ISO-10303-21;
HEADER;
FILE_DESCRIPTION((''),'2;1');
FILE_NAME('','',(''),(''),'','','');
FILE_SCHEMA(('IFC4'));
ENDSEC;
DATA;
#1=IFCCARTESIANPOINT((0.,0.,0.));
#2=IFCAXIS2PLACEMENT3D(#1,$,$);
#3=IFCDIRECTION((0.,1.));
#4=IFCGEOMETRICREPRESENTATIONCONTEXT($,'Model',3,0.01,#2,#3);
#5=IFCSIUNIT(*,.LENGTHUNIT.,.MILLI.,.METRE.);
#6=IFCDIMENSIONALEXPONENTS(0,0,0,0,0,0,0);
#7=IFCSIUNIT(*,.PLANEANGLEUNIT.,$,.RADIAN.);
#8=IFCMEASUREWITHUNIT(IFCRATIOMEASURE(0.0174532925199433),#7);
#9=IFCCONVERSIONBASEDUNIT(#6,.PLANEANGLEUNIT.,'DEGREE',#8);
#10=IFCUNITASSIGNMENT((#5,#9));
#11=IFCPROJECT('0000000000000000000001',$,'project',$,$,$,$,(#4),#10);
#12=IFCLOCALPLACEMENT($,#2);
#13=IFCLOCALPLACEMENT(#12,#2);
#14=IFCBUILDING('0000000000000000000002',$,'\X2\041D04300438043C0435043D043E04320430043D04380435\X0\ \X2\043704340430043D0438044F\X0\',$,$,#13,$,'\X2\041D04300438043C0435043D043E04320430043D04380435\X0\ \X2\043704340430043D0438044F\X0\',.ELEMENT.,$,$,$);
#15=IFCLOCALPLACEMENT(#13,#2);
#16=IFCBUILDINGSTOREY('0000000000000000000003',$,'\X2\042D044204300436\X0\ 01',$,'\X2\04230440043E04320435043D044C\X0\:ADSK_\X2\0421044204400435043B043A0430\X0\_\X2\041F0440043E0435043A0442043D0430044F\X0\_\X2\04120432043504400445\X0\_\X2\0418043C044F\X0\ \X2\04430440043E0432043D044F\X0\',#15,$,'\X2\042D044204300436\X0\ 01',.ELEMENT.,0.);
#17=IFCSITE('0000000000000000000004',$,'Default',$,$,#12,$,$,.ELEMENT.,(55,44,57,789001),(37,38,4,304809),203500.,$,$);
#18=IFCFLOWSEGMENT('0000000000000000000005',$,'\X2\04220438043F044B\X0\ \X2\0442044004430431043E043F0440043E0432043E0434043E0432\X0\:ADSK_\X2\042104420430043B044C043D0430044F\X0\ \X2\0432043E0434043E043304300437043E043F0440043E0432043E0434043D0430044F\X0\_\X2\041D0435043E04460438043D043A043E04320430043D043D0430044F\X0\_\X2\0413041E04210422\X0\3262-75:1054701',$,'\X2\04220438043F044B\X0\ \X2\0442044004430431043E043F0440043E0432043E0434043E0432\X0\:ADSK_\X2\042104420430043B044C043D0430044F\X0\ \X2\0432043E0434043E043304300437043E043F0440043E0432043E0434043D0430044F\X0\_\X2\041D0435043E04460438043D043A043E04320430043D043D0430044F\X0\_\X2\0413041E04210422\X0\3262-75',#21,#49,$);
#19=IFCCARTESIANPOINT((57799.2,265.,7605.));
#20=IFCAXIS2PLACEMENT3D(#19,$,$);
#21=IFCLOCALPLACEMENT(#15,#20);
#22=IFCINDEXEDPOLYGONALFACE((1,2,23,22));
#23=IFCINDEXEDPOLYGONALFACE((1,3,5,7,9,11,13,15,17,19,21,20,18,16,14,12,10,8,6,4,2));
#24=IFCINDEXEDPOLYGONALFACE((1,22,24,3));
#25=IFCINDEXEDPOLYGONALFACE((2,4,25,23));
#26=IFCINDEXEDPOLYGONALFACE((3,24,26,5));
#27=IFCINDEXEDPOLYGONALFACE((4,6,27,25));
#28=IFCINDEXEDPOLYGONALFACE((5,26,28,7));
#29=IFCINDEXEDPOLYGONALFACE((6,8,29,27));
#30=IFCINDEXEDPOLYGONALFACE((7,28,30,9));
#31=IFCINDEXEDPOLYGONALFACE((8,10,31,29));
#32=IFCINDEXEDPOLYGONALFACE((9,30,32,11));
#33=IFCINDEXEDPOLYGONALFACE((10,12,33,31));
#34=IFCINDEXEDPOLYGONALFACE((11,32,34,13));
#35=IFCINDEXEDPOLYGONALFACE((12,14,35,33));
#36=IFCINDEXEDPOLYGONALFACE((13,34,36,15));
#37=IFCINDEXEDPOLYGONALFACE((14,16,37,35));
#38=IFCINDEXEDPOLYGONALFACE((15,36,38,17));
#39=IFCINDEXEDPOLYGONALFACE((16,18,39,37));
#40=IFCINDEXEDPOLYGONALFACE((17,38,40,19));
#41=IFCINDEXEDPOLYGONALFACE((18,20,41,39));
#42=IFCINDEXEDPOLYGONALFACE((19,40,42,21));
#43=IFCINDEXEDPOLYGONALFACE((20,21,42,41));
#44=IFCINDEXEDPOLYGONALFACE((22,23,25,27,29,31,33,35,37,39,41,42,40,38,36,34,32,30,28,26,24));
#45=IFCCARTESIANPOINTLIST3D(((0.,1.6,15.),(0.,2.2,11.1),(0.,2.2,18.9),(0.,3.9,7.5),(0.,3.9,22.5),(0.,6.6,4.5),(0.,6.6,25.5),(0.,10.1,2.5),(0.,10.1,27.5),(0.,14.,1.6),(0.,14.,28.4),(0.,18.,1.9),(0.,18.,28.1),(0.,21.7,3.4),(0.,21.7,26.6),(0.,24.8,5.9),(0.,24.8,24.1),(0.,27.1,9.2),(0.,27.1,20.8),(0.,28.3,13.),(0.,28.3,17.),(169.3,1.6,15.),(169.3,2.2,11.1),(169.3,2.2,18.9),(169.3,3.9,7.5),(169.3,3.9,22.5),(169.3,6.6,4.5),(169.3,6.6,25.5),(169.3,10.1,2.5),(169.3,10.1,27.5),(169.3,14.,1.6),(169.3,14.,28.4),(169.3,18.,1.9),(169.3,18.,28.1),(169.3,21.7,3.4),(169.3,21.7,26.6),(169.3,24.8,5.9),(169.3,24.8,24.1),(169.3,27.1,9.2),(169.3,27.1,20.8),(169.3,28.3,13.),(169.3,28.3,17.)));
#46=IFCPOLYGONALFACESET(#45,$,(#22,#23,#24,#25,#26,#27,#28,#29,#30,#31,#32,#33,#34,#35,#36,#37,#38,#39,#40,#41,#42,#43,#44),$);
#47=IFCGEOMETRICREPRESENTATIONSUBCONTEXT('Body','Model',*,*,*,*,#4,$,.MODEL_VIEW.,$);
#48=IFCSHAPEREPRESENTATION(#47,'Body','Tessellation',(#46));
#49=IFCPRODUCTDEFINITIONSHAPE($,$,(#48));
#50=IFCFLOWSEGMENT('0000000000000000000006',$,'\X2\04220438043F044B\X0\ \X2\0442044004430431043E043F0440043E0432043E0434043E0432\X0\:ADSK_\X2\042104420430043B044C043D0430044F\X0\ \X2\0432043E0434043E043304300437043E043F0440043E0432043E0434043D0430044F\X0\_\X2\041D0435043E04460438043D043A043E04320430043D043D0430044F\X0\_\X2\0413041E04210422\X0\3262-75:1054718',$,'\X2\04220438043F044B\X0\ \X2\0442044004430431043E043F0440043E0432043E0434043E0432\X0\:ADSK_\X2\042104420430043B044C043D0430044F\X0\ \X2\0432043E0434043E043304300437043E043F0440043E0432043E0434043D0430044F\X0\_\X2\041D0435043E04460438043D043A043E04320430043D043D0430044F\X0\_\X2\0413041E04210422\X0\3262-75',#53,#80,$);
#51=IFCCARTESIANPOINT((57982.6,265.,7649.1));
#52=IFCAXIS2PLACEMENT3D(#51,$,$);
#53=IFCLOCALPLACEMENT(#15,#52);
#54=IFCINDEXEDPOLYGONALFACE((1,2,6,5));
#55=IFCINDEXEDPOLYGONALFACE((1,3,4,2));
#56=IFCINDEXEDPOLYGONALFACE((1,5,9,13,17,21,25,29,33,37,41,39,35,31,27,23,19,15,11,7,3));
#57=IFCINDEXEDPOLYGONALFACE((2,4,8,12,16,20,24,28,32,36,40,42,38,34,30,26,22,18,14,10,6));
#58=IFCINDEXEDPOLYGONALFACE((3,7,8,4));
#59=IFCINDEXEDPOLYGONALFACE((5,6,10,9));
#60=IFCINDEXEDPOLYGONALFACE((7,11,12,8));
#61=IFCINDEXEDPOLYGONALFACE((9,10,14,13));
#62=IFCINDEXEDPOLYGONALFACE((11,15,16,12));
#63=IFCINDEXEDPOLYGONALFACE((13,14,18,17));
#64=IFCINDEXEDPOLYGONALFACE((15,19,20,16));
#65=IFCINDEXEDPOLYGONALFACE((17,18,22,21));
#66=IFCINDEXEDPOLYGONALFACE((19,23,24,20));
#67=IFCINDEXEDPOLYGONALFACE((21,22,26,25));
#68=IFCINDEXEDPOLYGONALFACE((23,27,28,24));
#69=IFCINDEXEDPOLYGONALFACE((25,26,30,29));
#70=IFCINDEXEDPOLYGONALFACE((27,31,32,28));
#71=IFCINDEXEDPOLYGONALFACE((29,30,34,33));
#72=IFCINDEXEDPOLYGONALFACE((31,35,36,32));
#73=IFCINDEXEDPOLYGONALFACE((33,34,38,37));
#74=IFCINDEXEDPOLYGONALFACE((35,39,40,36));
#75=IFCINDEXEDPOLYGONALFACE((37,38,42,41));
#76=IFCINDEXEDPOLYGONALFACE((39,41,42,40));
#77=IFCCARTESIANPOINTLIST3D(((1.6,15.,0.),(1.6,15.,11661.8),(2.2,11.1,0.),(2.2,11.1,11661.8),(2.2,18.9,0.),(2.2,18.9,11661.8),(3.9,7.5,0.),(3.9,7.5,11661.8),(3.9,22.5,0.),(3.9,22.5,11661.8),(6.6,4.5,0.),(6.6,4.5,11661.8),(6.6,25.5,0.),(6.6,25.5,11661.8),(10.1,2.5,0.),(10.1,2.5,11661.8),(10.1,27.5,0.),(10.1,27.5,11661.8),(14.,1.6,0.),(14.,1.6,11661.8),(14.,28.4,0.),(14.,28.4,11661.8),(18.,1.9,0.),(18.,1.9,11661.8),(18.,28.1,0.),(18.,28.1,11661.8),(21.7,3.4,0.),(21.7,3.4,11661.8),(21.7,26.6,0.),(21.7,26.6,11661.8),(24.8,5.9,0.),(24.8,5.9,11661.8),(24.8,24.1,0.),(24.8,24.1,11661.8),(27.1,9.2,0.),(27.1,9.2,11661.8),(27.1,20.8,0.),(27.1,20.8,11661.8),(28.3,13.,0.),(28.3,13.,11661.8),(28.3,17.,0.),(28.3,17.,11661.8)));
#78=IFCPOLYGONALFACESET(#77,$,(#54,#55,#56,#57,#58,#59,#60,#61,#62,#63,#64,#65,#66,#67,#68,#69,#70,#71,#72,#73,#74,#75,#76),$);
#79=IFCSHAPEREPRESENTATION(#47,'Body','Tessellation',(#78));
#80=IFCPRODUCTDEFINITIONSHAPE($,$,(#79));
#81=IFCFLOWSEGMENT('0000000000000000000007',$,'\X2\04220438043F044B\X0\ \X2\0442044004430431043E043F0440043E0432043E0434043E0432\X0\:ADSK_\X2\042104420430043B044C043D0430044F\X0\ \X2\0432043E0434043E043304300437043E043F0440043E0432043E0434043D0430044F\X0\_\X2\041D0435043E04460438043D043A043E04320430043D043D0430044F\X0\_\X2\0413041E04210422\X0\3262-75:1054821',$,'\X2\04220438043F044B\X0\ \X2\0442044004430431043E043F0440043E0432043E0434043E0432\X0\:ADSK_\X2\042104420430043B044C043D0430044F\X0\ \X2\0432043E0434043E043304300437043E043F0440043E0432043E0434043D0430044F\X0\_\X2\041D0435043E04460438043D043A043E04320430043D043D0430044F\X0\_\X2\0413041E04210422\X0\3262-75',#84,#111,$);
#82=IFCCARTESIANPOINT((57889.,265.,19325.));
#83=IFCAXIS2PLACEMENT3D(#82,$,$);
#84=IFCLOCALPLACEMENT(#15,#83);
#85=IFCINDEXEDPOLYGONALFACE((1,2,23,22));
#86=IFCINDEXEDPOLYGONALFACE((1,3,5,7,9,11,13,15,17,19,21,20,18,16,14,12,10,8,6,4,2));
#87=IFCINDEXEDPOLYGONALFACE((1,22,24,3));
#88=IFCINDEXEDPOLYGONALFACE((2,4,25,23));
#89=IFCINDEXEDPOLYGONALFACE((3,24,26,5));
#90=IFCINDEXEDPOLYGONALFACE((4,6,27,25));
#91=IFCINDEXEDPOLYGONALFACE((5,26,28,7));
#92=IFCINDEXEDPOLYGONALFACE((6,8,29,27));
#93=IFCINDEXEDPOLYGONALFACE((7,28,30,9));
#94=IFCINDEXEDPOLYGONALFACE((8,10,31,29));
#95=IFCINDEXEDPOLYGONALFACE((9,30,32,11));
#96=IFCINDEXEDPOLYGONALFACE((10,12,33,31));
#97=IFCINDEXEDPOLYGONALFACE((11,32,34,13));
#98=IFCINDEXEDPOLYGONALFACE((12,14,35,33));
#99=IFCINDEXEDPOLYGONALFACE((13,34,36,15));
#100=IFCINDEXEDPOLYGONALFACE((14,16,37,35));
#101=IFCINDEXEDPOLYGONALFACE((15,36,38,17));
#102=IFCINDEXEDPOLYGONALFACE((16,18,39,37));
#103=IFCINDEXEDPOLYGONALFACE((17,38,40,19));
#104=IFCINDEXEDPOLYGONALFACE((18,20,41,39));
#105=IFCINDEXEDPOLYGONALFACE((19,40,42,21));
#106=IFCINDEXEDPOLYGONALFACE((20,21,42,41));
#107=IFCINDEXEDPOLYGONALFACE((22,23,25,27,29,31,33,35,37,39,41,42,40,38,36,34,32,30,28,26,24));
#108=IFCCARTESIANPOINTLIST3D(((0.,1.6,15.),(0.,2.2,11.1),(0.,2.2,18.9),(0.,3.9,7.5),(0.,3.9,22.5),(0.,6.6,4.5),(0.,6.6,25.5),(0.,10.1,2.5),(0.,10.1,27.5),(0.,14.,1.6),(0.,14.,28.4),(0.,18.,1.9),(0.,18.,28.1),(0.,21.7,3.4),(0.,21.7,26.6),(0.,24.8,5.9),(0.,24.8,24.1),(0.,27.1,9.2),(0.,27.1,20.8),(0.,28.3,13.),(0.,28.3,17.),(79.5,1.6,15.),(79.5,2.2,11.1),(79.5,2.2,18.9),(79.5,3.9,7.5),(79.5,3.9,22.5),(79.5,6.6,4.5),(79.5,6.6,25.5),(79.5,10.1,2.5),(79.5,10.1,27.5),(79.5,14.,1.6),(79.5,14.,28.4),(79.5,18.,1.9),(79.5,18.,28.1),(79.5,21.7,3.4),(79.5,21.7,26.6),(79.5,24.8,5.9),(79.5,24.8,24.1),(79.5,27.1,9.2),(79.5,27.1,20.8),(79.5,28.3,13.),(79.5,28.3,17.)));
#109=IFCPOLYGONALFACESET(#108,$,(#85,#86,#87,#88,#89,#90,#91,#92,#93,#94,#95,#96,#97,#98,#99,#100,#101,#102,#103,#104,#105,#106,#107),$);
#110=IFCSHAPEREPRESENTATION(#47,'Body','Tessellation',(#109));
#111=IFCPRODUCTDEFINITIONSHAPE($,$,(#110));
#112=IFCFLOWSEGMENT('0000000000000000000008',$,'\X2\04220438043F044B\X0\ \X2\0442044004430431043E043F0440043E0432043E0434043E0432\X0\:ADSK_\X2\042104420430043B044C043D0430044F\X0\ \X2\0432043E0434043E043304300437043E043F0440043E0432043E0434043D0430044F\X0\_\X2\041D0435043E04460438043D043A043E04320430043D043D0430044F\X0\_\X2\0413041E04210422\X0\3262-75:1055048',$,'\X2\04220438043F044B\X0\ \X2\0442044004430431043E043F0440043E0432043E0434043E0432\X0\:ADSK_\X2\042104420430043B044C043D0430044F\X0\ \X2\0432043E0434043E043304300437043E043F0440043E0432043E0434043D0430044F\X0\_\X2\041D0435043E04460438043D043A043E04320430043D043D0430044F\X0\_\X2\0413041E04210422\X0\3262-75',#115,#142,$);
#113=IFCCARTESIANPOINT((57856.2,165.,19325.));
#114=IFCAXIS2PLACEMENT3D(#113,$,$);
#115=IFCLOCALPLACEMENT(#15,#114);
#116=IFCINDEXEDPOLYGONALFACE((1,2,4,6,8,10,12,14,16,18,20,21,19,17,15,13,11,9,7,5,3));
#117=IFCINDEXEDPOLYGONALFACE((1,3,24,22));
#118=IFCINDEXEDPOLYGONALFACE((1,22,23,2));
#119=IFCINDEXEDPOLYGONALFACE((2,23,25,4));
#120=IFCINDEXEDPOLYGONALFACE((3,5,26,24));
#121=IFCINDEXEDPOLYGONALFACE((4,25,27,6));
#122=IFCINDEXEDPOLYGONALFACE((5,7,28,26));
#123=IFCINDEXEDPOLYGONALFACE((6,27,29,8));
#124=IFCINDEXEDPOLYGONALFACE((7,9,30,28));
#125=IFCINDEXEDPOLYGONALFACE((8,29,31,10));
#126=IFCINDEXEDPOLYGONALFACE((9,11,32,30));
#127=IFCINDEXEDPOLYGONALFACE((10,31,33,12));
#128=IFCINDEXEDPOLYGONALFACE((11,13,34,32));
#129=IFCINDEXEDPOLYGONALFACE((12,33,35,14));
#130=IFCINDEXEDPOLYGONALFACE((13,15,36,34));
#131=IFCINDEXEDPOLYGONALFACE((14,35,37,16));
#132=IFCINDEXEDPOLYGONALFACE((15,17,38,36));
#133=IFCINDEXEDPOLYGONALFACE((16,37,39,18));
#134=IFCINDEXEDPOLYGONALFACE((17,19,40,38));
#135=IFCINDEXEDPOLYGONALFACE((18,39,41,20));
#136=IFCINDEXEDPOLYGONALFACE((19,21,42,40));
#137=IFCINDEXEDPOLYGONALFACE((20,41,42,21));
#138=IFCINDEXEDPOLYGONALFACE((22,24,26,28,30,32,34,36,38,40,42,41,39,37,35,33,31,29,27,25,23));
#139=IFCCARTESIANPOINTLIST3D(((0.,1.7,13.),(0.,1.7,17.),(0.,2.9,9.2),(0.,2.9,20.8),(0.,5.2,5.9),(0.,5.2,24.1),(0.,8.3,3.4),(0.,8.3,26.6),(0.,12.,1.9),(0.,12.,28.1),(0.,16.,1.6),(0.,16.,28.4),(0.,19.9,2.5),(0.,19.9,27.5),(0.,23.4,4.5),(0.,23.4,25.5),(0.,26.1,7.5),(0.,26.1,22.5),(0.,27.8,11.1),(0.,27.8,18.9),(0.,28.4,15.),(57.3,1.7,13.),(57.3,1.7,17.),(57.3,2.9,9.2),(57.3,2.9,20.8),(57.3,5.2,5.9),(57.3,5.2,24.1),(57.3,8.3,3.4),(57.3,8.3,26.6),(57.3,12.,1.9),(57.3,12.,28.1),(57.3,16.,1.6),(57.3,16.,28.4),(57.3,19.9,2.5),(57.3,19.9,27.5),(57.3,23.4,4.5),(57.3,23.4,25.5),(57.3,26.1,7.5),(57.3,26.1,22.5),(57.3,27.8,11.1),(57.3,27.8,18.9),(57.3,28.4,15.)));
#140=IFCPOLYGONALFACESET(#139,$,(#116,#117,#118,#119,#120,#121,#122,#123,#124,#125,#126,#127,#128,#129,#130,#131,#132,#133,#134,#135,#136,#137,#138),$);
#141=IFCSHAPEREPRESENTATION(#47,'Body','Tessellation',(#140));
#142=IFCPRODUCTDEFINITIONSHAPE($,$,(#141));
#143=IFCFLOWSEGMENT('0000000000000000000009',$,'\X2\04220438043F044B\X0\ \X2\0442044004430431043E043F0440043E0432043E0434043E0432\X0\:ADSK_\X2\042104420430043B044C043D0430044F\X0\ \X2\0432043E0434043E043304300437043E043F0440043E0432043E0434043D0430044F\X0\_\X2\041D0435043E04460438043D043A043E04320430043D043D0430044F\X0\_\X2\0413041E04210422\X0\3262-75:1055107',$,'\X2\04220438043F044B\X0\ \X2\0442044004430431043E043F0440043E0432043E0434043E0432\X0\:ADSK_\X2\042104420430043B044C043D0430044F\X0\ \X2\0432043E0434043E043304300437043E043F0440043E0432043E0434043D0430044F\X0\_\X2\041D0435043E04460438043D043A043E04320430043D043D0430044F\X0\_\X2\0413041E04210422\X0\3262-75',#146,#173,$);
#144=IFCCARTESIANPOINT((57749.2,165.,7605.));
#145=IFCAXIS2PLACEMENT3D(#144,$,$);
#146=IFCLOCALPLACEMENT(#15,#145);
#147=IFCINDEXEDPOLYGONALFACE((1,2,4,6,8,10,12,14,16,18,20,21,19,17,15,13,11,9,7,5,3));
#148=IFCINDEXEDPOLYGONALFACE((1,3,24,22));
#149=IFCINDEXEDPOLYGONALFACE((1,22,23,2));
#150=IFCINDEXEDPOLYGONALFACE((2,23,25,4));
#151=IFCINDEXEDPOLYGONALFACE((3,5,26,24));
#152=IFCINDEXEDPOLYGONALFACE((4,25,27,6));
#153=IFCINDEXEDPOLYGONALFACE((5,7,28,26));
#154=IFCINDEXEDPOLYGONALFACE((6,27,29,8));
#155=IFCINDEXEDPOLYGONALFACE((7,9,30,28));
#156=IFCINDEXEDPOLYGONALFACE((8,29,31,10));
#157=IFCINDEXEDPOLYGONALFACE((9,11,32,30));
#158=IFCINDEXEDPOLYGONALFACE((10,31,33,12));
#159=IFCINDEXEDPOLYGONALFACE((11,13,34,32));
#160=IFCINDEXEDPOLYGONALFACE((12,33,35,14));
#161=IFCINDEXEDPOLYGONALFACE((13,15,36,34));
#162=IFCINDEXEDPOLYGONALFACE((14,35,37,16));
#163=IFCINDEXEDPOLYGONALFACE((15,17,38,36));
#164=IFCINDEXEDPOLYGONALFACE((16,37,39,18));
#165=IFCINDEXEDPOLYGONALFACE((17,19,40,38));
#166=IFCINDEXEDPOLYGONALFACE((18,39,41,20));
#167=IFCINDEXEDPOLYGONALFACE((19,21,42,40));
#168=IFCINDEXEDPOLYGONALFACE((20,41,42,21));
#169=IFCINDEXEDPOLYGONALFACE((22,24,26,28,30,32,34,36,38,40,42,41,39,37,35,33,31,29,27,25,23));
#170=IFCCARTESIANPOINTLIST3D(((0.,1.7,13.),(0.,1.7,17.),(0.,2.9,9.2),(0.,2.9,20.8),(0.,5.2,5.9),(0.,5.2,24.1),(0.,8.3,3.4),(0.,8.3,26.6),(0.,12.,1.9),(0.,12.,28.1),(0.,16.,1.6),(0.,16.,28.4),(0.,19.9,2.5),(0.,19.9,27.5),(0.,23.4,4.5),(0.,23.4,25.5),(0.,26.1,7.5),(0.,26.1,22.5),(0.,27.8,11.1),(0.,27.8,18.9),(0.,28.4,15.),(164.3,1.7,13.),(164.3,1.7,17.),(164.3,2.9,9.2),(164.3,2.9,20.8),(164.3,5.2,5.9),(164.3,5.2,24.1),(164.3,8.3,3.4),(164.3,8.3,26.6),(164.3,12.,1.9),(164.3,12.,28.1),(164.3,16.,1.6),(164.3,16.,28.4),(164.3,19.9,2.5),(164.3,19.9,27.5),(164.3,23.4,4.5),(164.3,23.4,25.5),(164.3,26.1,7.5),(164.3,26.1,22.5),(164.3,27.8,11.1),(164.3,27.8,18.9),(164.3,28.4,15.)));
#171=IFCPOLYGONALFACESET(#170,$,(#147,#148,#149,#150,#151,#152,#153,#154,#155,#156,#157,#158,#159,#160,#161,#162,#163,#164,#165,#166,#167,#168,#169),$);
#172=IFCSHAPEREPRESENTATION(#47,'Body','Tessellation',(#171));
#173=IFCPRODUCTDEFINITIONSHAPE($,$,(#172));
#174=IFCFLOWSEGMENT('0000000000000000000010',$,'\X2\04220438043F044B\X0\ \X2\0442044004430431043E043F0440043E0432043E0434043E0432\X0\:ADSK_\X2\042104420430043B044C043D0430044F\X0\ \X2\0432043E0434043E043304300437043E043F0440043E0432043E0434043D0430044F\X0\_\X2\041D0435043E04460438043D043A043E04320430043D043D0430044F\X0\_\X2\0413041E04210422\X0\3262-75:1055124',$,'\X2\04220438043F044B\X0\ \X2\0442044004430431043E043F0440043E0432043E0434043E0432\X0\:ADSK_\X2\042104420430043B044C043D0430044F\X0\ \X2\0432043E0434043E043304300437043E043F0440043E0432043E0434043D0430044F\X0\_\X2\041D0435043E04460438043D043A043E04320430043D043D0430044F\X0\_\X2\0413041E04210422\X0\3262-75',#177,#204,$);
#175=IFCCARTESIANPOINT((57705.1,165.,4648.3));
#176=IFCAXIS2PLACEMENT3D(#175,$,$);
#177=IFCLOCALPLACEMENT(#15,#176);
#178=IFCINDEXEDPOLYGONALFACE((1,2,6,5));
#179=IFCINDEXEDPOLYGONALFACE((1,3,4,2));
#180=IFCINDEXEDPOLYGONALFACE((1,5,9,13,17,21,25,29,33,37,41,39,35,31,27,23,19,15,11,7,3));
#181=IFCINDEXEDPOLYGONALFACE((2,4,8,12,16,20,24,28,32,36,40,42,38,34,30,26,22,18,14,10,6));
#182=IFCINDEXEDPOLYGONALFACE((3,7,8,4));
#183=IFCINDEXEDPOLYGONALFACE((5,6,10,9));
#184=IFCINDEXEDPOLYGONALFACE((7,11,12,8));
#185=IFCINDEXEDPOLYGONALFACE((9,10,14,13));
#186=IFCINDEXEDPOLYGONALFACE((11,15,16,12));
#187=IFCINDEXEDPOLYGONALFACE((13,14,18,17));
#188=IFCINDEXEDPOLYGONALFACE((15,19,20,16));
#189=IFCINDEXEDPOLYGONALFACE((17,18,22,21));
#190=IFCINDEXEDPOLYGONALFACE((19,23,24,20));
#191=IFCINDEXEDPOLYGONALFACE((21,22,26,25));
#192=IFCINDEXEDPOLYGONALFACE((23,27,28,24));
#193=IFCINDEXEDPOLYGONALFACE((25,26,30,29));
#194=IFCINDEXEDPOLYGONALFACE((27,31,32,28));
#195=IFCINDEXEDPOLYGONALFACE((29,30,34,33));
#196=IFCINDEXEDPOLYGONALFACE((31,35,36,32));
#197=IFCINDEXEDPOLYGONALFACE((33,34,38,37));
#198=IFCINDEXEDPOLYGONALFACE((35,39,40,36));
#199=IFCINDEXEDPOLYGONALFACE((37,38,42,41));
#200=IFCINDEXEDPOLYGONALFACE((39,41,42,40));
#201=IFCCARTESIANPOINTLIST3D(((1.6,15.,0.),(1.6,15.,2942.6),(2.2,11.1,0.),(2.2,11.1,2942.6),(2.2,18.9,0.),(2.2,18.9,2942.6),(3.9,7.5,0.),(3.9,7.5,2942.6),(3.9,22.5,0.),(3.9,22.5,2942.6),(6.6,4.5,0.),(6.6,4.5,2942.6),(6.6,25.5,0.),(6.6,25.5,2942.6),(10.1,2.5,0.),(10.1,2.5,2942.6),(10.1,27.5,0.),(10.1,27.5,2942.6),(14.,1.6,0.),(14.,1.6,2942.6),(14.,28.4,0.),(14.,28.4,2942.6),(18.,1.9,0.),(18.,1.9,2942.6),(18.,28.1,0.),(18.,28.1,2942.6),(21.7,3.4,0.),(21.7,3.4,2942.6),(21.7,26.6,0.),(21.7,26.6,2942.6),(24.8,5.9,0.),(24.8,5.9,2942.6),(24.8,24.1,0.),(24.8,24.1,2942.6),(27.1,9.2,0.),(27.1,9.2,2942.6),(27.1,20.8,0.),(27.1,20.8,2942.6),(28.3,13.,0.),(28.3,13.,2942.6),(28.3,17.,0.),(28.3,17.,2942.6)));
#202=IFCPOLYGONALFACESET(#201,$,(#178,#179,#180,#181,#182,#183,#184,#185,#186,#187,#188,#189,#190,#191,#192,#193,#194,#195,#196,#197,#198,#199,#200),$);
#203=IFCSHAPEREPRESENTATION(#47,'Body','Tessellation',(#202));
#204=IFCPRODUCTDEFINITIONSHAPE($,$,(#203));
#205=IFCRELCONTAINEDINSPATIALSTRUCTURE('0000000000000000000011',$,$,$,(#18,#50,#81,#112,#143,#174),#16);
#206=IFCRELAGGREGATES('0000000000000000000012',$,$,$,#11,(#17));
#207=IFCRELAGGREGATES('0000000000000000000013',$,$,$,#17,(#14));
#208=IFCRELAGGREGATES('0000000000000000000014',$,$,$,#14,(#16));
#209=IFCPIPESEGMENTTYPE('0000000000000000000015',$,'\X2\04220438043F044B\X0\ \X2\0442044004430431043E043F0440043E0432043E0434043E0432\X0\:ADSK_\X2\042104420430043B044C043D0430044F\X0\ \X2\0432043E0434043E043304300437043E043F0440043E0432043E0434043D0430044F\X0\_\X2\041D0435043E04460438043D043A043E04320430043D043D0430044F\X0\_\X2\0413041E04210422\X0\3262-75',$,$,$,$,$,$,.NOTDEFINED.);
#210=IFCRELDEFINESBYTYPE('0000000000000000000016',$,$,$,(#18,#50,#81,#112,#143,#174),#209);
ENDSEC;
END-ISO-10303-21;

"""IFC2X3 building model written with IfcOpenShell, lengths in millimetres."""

from ifc_helpers import new_model, entity, si_unit, converted_unit, direction, frame, origin, origin_2d_with_axis, place, context, subcontext, project, spatial, circle, extrude, type_object, element, save


model = new_model("IFC2X3")

# Units and contexts
model_context = context("Model", 3, precision=0.01, world=origin(), true_north=direction((0.0, 1.0)))
body_context = subcontext(model_context, "Body", "Model", "MODEL_VIEW")
ifc_project = project(units=[si_unit("LENGTHUNIT", "METRE", prefix="MILLI"), converted_unit("PLANEANGLEUNIT", "DEGREE", entity("IfcRatioMeasure", 0.0174532925199433), si_unit("PLANEANGLEUNIT", "RADIAN"), dimensions=[0, 0, 0, 0, 0, 0, 0])], contexts=[model_context])

# Site, building, storey
site_placement = place(None, origin())
site = spatial("IfcSite", under=ifc_project, at=site_placement, Name="Default", CompositionType="ELEMENT", RefLatitude=(55, 44, 57, 789001), RefLongitude=(37, 38, 4, 304809), RefElevation=203500.0)
building_placement = place(site_placement, origin())
building = spatial("IfcBuilding", under=site, at=building_placement, Name="Наименование здания", LongName="Наименование здания", CompositionType="ELEMENT")
storey_placement = place(building_placement, origin())
storey = spatial("IfcBuildingStorey", under=building, at=storey_placement, Name="Этаж 01", ObjectType="Уровень:ADSK_Стрелка_Проектная_Вверх_Имя уровня", LongName="Этаж 01", CompositionType="ELEMENT", Elevation=0.0)

# Flow segments
pipe_segment_type = type_object("IfcPipeSegmentType", Name="Типы трубопроводов:ADSK_Стальная водогазопроводная_Неоцинкованная_ГОСТ3262-75", PredefinedType="NOTDEFINED")
flow_segment_1_placement = place(storey_placement, frame((57799.2, 265.0, 7605.0)))
element("IfcFlowSegment", 1, at=flow_segment_1_placement, inside=storey, type_object=pipe_segment_type, Name="Типы трубопроводов:ADSK_Стальная водогазопроводная_Неоцинкованная_ГОСТ3262-75:1054701", ObjectType="Типы трубопроводов:ADSK_Стальная водогазопроводная_Неоцинкованная_ГОСТ3262-75", context=body_context, shape_type="SweptSolid", body=[
    extrude(circle(Radius=13.4, at=origin_2d_with_axis()), frame((0.0, 15.0, 15.0), z_axis=(1.0, 0.0, 0.0), x_axis=(0.0, -1.0, 0.0)), (0.0, 0.0, 1.0), 169.3),
])
flow_segment_2_placement = place(storey_placement, frame((57982.6, 265.0, 7649.1)))
element("IfcFlowSegment", 2, at=flow_segment_2_placement, inside=storey, type_object=pipe_segment_type, Name="Типы трубопроводов:ADSK_Стальная водогазопроводная_Неоцинкованная_ГОСТ3262-75:1054718", ObjectType="Типы трубопроводов:ADSK_Стальная водогазопроводная_Неоцинкованная_ГОСТ3262-75", context=body_context, shape_type="SweptSolid", body=[
    extrude(circle(Radius=13.4, at=origin_2d_with_axis()), frame((15.0, 15.0, 0.0), z_axis=(0.0, 0.0, 1.0), x_axis=(-1.0, 0.0, 0.0)), (0.0, 0.0, 1.0), 11661.8),
])
flow_segment_3_placement = place(storey_placement, frame((57889.0, 265.0, 19325.0)))
element("IfcFlowSegment", 3, at=flow_segment_3_placement, inside=storey, type_object=pipe_segment_type, Name="Типы трубопроводов:ADSK_Стальная водогазопроводная_Неоцинкованная_ГОСТ3262-75:1054821", ObjectType="Типы трубопроводов:ADSK_Стальная водогазопроводная_Неоцинкованная_ГОСТ3262-75", context=body_context, shape_type="SweptSolid", body=[
    extrude(circle(Radius=13.4, at=origin_2d_with_axis()), frame((0.0, 15.0, 15.0), z_axis=(1.0, 0.0, 0.0), x_axis=(0.0, -1.0, 0.0)), (0.0, 0.0, 1.0), 79.5),
])
flow_segment_4_placement = place(storey_placement, frame((57856.2, 165.0, 19325.0)))
element("IfcFlowSegment", 4, at=flow_segment_4_placement, inside=storey, type_object=pipe_segment_type, Name="Типы трубопроводов:ADSK_Стальная водогазопроводная_Неоцинкованная_ГОСТ3262-75:1055048", ObjectType="Типы трубопроводов:ADSK_Стальная водогазопроводная_Неоцинкованная_ГОСТ3262-75", context=body_context, shape_type="SweptSolid", body=[
    extrude(circle(Radius=13.4, at=origin_2d_with_axis()), frame((0.0, 15.0, 15.0), z_axis=(1.0, 0.0, 0.0), x_axis=(0.0, 1.0, 0.0)), (0.0, 0.0, 1.0), 57.3),
])
flow_segment_5_placement = place(storey_placement, frame((57749.2, 165.0, 7605.0)))
element("IfcFlowSegment", 5, at=flow_segment_5_placement, inside=storey, type_object=pipe_segment_type, Name="Типы трубопроводов:ADSK_Стальная водогазопроводная_Неоцинкованная_ГОСТ3262-75:1055107", ObjectType="Типы трубопроводов:ADSK_Стальная водогазопроводная_Неоцинкованная_ГОСТ3262-75", context=body_context, shape_type="SweptSolid", body=[
    extrude(circle(Radius=13.4, at=origin_2d_with_axis()), frame((0.0, 15.0, 15.0), z_axis=(1.0, 0.0, 0.0), x_axis=(0.0, 1.0, 0.0)), (0.0, 0.0, 1.0), 164.3),
])
flow_segment_6_placement = place(storey_placement, frame((57705.1, 165.0, 4648.3)))
element("IfcFlowSegment", 6, at=flow_segment_6_placement, inside=storey, type_object=pipe_segment_type, Name="Типы трубопроводов:ADSK_Стальная водогазопроводная_Неоцинкованная_ГОСТ3262-75:1055124", ObjectType="Типы трубопроводов:ADSK_Стальная водогазопроводная_Неоцинкованная_ГОСТ3262-75", context=body_context, shape_type="SweptSolid", body=[
    extrude(circle(Radius=13.4, at=origin_2d_with_axis()), frame((15.0, 15.0, 0.0), z_axis=(0.0, 0.0, 1.0), x_axis=(-1.0, 0.0, 0.0)), (0.0, 0.0, 1.0), 2942.6),
])

save(model, "model.ifc")
